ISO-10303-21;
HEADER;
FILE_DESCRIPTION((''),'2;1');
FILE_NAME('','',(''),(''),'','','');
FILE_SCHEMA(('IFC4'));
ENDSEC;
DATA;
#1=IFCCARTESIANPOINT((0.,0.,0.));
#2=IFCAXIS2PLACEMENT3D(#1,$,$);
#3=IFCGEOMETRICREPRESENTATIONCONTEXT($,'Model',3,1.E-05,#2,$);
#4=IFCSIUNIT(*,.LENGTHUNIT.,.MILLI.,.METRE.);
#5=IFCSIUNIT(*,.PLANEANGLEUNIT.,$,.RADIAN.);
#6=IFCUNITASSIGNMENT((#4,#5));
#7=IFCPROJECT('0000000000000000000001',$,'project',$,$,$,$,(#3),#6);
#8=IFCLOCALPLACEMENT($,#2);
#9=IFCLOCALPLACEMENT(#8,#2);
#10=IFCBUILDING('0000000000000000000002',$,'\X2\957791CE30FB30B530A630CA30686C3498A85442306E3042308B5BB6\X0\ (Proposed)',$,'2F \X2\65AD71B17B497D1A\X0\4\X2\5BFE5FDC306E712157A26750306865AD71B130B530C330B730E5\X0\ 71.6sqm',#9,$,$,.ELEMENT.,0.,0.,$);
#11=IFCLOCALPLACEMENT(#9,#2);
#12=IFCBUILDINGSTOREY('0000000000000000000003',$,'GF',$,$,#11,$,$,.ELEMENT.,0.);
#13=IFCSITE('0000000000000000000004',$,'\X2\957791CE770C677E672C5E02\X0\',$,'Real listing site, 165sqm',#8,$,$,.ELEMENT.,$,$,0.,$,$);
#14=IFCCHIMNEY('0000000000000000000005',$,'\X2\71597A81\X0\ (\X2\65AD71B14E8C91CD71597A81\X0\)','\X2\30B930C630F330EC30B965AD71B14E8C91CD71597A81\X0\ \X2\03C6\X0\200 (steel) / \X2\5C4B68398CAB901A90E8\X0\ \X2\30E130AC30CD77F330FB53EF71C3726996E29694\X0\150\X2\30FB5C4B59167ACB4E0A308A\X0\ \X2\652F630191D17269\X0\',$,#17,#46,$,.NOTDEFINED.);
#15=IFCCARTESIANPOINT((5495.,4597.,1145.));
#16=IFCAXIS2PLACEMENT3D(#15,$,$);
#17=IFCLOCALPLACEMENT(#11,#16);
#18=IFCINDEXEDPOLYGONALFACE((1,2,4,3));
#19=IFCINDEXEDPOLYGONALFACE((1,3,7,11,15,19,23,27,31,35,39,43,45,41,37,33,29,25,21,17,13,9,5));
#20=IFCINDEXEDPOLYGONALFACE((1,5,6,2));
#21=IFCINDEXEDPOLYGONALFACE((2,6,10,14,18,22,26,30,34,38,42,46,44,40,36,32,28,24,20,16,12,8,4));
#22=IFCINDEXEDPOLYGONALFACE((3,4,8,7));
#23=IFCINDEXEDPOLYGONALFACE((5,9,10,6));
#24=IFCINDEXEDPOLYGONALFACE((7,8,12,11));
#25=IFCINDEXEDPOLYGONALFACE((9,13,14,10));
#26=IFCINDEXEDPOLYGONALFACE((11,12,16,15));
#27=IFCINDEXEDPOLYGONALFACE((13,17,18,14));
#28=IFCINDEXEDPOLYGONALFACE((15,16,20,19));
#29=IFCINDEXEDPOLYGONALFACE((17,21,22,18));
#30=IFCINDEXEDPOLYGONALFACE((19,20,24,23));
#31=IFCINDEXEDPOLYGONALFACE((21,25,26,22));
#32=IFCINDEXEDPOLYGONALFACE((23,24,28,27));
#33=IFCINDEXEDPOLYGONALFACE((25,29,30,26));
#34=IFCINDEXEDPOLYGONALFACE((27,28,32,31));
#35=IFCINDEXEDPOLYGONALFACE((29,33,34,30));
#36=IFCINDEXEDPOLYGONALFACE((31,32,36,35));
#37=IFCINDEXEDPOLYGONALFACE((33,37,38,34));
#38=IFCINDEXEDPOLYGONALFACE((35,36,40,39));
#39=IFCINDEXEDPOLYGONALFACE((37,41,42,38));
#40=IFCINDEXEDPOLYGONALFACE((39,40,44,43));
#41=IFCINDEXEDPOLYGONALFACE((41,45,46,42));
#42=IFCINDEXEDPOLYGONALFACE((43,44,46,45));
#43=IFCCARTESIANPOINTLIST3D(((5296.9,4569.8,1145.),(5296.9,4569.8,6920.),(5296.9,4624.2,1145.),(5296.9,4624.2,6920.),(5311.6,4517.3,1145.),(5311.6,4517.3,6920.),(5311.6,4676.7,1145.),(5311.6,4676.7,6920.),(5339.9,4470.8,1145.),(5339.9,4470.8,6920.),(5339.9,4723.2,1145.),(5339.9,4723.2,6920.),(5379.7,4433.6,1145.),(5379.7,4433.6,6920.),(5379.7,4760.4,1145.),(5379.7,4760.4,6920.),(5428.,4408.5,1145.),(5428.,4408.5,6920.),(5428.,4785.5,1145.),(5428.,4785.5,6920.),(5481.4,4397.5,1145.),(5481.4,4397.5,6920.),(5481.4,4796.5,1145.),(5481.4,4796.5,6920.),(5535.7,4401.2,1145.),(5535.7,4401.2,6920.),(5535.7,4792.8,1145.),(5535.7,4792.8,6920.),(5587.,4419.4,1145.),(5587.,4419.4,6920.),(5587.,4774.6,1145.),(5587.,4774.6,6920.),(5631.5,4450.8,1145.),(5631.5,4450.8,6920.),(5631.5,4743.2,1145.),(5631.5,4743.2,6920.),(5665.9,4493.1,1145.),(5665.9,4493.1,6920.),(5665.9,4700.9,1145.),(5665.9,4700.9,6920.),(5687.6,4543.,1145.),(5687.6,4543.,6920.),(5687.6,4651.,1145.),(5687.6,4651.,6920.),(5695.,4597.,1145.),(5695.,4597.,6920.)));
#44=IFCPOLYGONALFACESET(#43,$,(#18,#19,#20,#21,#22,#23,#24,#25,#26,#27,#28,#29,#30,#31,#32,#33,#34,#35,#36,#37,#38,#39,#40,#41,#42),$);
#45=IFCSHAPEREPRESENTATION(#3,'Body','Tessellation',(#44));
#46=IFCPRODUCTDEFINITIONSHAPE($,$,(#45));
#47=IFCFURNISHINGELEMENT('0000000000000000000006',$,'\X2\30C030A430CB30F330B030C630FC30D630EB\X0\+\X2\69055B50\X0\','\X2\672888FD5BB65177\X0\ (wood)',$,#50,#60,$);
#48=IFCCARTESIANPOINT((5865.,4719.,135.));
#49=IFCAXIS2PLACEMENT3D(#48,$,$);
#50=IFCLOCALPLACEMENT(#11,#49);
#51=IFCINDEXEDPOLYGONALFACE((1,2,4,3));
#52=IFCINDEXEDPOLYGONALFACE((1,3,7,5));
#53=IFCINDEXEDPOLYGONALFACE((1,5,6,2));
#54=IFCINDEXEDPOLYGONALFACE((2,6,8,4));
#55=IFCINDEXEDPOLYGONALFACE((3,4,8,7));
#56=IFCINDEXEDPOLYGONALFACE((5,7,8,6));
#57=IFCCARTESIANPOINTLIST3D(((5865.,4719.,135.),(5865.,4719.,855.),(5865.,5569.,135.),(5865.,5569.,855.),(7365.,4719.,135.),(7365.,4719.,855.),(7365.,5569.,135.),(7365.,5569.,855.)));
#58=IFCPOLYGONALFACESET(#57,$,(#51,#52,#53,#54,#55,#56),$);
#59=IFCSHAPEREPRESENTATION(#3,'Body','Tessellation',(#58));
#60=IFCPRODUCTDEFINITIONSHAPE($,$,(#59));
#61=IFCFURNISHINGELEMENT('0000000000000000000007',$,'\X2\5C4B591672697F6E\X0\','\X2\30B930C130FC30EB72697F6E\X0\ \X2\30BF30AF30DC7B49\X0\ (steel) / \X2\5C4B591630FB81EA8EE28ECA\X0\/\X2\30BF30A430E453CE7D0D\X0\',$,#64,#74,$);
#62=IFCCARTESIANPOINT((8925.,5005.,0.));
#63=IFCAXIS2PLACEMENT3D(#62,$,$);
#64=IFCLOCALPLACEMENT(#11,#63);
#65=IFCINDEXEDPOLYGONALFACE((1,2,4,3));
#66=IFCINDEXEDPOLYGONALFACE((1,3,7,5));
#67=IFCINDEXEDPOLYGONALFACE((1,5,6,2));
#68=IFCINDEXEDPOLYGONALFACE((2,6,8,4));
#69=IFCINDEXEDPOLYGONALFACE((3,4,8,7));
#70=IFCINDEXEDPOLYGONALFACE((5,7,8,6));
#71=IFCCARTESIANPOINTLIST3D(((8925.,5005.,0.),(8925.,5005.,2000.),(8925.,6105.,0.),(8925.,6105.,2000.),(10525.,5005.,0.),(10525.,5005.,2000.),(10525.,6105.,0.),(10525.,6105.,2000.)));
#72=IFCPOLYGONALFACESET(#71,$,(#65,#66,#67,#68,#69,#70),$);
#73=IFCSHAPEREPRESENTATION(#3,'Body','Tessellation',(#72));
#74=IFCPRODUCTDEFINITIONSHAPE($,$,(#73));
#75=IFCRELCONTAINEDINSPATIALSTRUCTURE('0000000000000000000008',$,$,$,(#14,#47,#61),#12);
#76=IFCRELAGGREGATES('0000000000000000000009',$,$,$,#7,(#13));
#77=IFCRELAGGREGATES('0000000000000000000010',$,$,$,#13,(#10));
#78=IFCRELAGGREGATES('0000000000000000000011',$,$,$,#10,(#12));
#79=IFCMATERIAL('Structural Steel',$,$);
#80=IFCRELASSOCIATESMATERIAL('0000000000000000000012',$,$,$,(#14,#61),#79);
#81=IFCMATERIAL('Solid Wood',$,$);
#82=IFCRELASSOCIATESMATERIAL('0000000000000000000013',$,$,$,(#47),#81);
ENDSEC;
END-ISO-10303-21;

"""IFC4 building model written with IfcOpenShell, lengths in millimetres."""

from ifc_helpers import new_model, si_unit, frame, frame_2d, origin, origin_2d, place, context, project, spatial, rectangle, circle, extrude, material, element, save


model = new_model("IFC4")

# Units and contexts
model_context = context("Model", 3, precision=1e-05, world=origin())
ifc_project = project(units=[si_unit("LENGTHUNIT", "METRE", prefix="MILLI"), si_unit("PLANEANGLEUNIT", "RADIAN")], contexts=[model_context])

# Site, building, storey
site_placement = place(None, origin())
site = spatial("IfcSite", under=ifc_project, at=site_placement, Name="長野県松本市", ObjectType="Real listing site, 165sqm", CompositionType="ELEMENT", RefElevation=0.0)
building_placement = place(site_placement, origin())
building = spatial("IfcBuilding", under=site, at=building_placement, Name="長野・サウナと水風呂のある家 (Proposed)", ObjectType="2F 断熱等級4対応の無垢材と断熱サッシュ 71.6sqm", CompositionType="ELEMENT", ElevationOfRefHeight=0.0, ElevationOfTerrain=0.0)
storey_placement = place(building_placement, origin())
storey = spatial("IfcBuildingStorey", under=building, at=storey_placement, Name="GF", CompositionType="ELEMENT", Elevation=0.0)

# Shared definitions
ifc_material_1 = material(Name="Solid Wood")

# Shared definitions
ifc_material_2 = material(Name="Structural Steel")

# Chimney
chimney_placement = place(storey_placement, frame((5495.0, 4597.0, 1145.0)))
element("IfcChimney", 1, at=chimney_placement, inside=storey, material=ifc_material_2, Name="煙突 (断熱二重煙突)", Description="ステンレス断熱二重煙突 φ200 (steel) / 屋根貫通部 メガネ石・可燃物離隔150・屋外立上り 支持金物", PredefinedType="NOTDEFINED", context=model_context, shape_type="SweptSolid", body=[
    extrude(circle(Radius=200.0, at=origin_2d()), frame((5495.0, 4597.0, 1145.0)), (0.0, 0.0, 1.0), 5775.0),
])

# Furnishing elements
furnishing_1_placement = place(storey_placement, frame((5865.0, 4719.0, 135.0)))
element("IfcFurnishingElement", 2, at=furnishing_1_placement, inside=storey, material=ifc_material_1, Name="ダイニングテーブル+椅子", Description="木製家具 (wood)", context=model_context, shape_type="SweptSolid", body=[
    extrude(rectangle(XDim=1500.0, YDim=850.0, at=frame_2d((750.0, 425.0))), frame((5865.0, 4719.0, 135.0)), (0.0, 0.0, 1.0), 720.0),
])
furnishing_2_placement = place(storey_placement, frame((8925.0, 5005.0, 0.0)))
element("IfcFurnishingElement", 3, at=furnishing_2_placement, inside=storey, material=ifc_material_2, Name="屋外物置", Description="スチール物置 タクボ等 (steel) / 屋外・自転車/タイヤ収納", context=model_context, shape_type="SweptSolid", body=[
    extrude(rectangle(XDim=1600.0, YDim=1100.0, at=frame_2d((800.0, 550.0))), frame((8925.0, 5005.0, 0.0)), (0.0, 0.0, 1.0), 2000.0),
])

save(model, "model.ifc")
